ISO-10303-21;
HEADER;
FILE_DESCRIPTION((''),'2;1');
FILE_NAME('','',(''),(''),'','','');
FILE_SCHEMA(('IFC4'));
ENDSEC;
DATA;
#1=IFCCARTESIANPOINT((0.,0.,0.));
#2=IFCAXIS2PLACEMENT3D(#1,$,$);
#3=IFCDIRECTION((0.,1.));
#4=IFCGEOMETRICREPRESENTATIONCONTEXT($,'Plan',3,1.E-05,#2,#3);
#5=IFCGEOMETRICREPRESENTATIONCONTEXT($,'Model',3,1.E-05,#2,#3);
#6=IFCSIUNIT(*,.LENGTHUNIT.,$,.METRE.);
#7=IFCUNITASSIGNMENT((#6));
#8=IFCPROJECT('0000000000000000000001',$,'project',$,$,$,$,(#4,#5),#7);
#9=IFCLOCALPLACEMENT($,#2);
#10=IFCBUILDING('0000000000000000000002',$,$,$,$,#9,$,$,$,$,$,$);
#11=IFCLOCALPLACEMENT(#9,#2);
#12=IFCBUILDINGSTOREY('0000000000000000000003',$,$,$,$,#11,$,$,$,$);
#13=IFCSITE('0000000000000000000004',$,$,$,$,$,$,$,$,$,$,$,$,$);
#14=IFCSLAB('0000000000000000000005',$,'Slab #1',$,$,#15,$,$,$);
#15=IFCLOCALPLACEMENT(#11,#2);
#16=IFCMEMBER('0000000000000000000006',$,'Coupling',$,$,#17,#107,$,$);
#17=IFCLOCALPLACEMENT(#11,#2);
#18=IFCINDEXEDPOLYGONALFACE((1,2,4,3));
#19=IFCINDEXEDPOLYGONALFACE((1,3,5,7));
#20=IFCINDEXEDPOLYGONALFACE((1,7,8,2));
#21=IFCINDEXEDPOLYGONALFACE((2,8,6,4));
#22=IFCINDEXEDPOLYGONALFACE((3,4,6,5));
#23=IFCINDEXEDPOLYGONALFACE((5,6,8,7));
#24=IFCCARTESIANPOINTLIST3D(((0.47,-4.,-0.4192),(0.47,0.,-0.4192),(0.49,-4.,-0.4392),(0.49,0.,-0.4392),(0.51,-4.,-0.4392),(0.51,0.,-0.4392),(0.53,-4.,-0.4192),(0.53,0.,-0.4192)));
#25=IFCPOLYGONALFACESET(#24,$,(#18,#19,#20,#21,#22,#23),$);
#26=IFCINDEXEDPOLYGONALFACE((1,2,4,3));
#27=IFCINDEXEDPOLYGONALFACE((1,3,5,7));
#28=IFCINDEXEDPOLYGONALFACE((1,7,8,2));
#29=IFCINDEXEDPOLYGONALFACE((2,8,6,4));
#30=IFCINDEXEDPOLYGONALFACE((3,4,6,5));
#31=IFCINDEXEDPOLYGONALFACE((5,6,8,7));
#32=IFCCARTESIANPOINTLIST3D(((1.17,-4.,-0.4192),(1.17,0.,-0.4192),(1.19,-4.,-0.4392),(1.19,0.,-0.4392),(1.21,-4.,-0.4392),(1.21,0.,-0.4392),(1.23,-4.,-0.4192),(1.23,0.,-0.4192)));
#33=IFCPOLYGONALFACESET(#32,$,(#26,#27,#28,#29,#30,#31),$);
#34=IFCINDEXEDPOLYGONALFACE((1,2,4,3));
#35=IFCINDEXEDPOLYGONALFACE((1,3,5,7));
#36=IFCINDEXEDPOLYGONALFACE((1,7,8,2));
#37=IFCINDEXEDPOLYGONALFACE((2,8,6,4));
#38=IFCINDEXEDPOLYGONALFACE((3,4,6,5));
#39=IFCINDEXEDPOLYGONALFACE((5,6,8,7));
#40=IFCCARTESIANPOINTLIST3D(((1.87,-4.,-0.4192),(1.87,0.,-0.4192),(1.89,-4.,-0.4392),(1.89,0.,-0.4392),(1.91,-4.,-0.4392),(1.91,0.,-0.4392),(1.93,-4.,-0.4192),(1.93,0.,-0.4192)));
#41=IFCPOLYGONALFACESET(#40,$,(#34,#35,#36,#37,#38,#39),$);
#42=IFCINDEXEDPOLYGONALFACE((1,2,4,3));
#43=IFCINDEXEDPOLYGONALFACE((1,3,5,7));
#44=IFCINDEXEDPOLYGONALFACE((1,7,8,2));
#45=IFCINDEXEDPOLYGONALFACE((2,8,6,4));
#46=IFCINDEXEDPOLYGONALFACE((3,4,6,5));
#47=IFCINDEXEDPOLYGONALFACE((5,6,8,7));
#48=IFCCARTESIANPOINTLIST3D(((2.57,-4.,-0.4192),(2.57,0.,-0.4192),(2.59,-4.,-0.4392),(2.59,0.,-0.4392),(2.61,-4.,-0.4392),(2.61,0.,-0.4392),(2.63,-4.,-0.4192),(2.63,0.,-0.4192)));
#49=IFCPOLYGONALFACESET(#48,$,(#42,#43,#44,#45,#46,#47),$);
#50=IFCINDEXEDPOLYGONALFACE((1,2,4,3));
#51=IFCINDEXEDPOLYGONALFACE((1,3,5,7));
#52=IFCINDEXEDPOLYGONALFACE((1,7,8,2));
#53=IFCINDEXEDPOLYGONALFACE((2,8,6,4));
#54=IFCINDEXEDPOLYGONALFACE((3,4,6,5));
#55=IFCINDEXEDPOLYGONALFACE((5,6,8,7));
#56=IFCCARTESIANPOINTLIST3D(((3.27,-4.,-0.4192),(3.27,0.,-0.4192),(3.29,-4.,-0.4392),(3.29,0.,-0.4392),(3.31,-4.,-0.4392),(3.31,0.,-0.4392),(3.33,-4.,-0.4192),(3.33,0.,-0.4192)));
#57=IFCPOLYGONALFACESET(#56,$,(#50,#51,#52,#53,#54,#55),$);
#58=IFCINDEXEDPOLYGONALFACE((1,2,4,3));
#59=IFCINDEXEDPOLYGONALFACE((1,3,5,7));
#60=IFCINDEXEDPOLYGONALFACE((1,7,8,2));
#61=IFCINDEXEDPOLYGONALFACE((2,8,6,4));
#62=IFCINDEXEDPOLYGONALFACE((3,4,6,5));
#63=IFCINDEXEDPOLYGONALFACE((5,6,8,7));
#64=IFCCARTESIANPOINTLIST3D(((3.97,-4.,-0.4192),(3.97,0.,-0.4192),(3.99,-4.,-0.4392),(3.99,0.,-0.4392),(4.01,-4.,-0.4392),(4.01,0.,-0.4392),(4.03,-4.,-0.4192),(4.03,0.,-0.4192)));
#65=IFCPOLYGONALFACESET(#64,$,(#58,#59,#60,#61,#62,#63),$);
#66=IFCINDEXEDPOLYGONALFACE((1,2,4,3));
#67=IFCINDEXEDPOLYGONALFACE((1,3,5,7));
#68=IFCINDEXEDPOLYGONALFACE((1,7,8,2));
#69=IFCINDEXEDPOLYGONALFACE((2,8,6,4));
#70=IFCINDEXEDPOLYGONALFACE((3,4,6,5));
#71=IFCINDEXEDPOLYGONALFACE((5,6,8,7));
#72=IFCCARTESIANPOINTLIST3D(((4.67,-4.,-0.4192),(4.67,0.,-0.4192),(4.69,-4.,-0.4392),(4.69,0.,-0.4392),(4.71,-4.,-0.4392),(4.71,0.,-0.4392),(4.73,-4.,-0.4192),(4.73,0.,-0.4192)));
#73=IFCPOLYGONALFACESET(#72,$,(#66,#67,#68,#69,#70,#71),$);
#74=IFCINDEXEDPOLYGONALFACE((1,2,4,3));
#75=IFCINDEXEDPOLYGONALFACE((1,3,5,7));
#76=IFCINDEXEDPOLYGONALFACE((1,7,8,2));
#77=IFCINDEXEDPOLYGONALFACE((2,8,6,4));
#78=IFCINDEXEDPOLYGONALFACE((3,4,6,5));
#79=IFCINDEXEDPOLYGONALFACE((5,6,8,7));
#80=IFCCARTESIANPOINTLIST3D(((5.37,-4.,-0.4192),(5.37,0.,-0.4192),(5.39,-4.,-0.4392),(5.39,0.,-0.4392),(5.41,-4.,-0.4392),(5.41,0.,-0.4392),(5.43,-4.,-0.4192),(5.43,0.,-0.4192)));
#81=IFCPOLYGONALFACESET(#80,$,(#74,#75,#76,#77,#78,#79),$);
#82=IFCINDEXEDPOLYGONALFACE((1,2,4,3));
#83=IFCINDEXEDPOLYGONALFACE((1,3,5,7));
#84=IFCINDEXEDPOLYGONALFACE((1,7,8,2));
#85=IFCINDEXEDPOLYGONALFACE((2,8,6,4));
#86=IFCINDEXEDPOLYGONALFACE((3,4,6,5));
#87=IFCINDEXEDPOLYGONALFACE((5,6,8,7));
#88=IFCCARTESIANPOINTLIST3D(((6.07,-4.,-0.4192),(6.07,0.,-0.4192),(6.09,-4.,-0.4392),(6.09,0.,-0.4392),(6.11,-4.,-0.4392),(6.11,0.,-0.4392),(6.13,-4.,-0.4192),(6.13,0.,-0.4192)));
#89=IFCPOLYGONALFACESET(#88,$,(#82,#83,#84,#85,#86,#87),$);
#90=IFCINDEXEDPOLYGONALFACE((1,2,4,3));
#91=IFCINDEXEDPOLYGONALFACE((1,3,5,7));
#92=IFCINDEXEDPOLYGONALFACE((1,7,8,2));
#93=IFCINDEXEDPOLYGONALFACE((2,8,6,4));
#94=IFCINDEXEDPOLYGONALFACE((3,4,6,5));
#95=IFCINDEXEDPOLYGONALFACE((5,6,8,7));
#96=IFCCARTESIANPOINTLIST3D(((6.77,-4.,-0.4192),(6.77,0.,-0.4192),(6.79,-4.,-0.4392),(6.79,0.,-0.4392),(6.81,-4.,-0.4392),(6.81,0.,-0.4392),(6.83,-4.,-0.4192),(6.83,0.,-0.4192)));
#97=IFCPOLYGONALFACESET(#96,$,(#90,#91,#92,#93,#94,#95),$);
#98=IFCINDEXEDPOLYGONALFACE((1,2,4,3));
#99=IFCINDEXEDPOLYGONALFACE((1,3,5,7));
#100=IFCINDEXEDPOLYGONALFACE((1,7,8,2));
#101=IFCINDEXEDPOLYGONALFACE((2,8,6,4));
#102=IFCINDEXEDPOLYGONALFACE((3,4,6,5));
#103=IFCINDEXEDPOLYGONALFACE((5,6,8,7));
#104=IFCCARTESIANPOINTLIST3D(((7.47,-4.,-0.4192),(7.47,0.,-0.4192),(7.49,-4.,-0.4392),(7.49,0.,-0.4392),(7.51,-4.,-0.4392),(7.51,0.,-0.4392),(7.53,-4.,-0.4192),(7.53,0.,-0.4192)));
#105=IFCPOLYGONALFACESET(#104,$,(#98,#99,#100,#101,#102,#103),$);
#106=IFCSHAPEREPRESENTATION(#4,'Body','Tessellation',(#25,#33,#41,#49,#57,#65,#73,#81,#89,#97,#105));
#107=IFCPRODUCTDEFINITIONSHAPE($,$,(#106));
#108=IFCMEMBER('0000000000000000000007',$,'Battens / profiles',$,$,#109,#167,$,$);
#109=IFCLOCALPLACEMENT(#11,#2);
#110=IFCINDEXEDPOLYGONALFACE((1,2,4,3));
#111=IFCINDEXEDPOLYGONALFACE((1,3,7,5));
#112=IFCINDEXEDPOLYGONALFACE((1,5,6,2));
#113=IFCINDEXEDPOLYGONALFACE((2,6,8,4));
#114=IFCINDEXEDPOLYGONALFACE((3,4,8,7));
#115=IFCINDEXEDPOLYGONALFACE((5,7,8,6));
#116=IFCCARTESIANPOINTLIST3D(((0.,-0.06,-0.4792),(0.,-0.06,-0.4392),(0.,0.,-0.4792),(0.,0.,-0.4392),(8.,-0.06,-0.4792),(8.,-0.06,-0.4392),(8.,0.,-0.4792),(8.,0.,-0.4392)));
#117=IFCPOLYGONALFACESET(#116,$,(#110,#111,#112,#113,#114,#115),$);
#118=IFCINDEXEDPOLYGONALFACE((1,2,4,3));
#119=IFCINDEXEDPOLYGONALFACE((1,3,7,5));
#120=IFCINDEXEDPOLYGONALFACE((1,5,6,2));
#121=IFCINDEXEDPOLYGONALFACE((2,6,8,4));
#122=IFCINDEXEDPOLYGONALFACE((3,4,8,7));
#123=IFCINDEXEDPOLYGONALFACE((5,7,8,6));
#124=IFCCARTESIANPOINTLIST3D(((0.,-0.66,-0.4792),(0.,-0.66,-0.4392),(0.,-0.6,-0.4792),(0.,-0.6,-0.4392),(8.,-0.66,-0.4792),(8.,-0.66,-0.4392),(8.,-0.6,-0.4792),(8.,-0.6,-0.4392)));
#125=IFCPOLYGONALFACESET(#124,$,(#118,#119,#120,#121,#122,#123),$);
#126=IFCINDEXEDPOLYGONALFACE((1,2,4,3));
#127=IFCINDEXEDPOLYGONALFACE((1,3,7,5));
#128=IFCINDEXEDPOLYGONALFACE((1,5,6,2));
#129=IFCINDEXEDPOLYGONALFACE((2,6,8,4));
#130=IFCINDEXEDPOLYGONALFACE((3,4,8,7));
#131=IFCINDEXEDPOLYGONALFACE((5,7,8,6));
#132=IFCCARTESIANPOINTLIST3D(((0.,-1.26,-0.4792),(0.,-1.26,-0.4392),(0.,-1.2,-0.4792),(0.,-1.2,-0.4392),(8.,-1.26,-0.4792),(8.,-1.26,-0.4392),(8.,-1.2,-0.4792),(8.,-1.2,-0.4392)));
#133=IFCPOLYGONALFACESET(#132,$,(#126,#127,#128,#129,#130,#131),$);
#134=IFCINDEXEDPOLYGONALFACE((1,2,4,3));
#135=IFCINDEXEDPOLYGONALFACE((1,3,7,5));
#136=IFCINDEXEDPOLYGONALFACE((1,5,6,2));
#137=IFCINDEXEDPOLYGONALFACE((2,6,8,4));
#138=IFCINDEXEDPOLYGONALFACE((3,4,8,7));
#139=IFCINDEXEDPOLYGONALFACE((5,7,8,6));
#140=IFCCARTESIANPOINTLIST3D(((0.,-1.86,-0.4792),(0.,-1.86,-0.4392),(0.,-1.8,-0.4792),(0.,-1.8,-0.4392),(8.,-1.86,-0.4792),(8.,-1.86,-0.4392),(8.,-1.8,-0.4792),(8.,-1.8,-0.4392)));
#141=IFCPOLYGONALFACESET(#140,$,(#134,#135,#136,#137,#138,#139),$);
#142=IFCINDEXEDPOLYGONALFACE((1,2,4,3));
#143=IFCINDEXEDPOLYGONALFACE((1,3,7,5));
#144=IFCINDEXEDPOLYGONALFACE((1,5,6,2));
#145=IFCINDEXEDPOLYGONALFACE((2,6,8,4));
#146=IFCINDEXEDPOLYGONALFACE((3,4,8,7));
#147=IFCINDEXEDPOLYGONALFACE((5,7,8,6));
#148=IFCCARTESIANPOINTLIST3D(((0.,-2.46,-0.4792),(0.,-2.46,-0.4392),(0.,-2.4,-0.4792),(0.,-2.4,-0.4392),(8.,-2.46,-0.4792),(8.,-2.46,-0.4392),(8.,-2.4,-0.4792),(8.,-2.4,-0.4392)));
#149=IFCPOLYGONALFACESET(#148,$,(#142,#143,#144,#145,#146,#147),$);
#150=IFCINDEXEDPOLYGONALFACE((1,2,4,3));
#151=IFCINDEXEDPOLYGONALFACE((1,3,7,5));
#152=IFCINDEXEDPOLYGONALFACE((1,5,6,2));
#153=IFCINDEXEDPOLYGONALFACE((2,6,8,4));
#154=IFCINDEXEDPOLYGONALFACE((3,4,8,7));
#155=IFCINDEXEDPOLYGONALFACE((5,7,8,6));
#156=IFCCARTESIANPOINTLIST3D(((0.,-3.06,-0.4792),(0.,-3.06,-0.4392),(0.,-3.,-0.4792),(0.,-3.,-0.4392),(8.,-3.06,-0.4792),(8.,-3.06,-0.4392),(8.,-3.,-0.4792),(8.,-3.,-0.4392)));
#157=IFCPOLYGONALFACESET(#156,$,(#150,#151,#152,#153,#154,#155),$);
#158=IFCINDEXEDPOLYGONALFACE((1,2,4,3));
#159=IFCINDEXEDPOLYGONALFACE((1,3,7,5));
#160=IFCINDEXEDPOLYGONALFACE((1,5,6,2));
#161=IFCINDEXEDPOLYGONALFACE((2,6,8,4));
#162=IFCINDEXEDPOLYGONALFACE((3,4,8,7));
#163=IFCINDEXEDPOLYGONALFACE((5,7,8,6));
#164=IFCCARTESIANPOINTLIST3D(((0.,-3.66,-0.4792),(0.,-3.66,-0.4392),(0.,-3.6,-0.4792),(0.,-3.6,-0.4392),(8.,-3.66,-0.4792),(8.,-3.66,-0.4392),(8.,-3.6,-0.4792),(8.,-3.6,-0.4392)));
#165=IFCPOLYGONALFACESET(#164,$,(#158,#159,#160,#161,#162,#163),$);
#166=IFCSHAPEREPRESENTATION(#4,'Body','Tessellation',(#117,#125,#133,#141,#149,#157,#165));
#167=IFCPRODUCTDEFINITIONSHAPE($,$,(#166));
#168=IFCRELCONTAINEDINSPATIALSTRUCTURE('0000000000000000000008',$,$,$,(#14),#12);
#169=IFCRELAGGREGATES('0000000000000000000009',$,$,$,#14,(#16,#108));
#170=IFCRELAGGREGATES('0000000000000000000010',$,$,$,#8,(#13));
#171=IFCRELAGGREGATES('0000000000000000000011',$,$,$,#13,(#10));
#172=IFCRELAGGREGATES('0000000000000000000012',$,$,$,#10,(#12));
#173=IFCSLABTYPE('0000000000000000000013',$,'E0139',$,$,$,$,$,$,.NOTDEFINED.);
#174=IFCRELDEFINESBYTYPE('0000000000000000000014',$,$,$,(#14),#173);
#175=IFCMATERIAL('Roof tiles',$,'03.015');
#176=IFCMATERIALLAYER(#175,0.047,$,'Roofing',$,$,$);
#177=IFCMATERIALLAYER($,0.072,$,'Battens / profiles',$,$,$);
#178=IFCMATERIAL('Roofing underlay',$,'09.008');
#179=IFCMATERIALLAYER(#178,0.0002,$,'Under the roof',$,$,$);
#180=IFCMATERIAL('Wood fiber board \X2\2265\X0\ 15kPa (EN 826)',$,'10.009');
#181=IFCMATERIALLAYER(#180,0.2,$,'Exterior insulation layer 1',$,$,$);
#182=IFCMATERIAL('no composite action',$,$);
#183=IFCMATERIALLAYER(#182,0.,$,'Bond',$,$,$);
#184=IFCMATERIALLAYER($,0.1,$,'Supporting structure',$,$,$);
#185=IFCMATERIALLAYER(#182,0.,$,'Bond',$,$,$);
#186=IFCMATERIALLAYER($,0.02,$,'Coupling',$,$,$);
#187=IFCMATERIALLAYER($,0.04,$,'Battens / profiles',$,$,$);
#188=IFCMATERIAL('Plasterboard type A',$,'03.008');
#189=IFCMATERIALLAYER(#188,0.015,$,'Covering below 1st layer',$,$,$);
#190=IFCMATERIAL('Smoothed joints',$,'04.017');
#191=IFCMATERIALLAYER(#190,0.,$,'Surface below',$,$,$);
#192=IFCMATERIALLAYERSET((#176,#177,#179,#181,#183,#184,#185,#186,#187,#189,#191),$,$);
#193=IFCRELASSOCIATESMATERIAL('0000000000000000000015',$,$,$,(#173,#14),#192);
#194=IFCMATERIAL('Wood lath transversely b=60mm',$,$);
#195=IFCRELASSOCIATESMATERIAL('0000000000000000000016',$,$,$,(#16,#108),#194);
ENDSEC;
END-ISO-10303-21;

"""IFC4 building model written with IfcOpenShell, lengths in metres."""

from ifc_helpers import new_model, si_unit, direction, frame, frame_2d, origin, place, context, project, spatial, polyline, rectangle, outline, extrude, material, layer, layer_set, type_object, element, aggregate, save


model = new_model("IFC4")

# Units and contexts
plan_context = context("Plan", 3, precision=1e-05, world=origin(), true_north=direction((0.0, 1.0)))
model_context = context("Model", 3, precision=1e-05, world=origin(), true_north=direction((0.0, 1.0)))
ifc_project = project(units=[si_unit("LENGTHUNIT", "METRE")], contexts=[plan_context, model_context])

# Site, building, storey
site = spatial("IfcSite", under=ifc_project)
building_placement = place(None, origin())
building = spatial("IfcBuilding", under=site, at=building_placement)
storey_placement = place(building_placement, origin())
storey = spatial("IfcBuildingStorey", under=building, at=storey_placement)

# Slab, members
ifc_material_1 = material(Name="Roof tiles", Category="03.015")
ifc_layer_1 = layer(ifc_material_1, 0.047, Name="Roofing")
ifc_layer_2 = layer(None, 0.072, Name="Battens / profiles")
ifc_material_2 = material(Name="Roofing underlay", Category="09.008")
ifc_layer_3 = layer(ifc_material_2, 0.0002, Name="Under the roof")
ifc_material_3 = material(Name="Wood fiber board ≥ 15kPa (EN 826)", Category="10.009")
ifc_layer_4 = layer(ifc_material_3, 0.2, Name="Exterior insulation layer 1")
ifc_material_4 = material(Name="no composite action")
ifc_layer_5 = layer(ifc_material_4, 0.0, Name="Bond")
ifc_layer_6 = layer(None, 0.1, Name="Supporting structure")
ifc_layer_7 = layer(ifc_material_4, 0.0, Name="Bond")
ifc_layer_8 = layer(None, 0.02, Name="Coupling")
ifc_layer_9 = layer(None, 0.04, Name="Battens / profiles")
ifc_material_5 = material(Name="Plasterboard type A", Category="03.008")
ifc_layer_10 = layer(ifc_material_5, 0.015, Name="Covering below 1st layer")
ifc_material_6 = material(Name="Smoothed joints", Category="04.017")
ifc_layer_11 = layer(ifc_material_6, 0.0, Name="Surface below")
ifc_layer_set = layer_set([ifc_layer_1, ifc_layer_2, ifc_layer_3, ifc_layer_4, ifc_layer_5, ifc_layer_6, ifc_layer_7, ifc_layer_8, ifc_layer_9, ifc_layer_10, ifc_layer_11])
slab_type = type_object("IfcSlabType", Name="E0139", PredefinedType="NOTDEFINED", material=ifc_layer_set)
slab_placement = place(None, frame((0.0, 0.0, 0.0), z_axis=(0.0, 0.0, -1.0), x_axis=(1.0, 0.0, 0.0)))
slab = element("IfcSlab", 1, at=slab_placement, inside=storey, type_object=slab_type, material=ifc_layer_set, Name="Slab #1")
ifc_material_7 = material(Name="Wood lath transversely b=60mm")
member_1_placement = place(slab_placement, origin())
member_1 = element("IfcMember", 2, at=member_1_placement, material=ifc_material_7, Name="Coupling", context=plan_context, shape_type="SweptSolid", body=[
    extrude(outline(polyline([(0.0, 0.0), (0.06, 0.0), (0.04, 0.02), (0.02, 0.02), (0.0, 0.0)])), frame((0.47, 4.0, 0.4192), z_axis=(0.0, -1.0, 0.0), x_axis=(1.0, 0.0, 0.0)), (0.0, 0.0, 1.0), 4.0),
    extrude(outline(polyline([(0.0, 0.0), (0.06, 0.0), (0.04, 0.02), (0.02, 0.02), (0.0, 0.0)])), frame((1.17, 4.0, 0.4192), z_axis=(0.0, -1.0, 0.0), x_axis=(1.0, 0.0, 0.0)), (0.0, 0.0, 1.0), 4.0),
    extrude(outline(polyline([(0.0, 0.0), (0.06, 0.0), (0.04, 0.02), (0.02, 0.02), (0.0, 0.0)])), frame((1.87, 4.0, 0.4192), z_axis=(0.0, -1.0, 0.0), x_axis=(1.0, 0.0, 0.0)), (0.0, 0.0, 1.0), 4.0),
    extrude(outline(polyline([(0.0, 0.0), (0.06, 0.0), (0.04, 0.02), (0.02, 0.02), (0.0, 0.0)])), frame((2.57, 4.0, 0.4192), z_axis=(0.0, -1.0, 0.0), x_axis=(1.0, 0.0, 0.0)), (0.0, 0.0, 1.0), 4.0),
    extrude(outline(polyline([(0.0, 0.0), (0.06, 0.0), (0.04, 0.02), (0.02, 0.02), (0.0, 0.0)])), frame((3.27, 4.0, 0.4192), z_axis=(0.0, -1.0, 0.0), x_axis=(1.0, 0.0, 0.0)), (0.0, 0.0, 1.0), 4.0),
    extrude(outline(polyline([(0.0, 0.0), (0.06, 0.0), (0.04, 0.02), (0.02, 0.02), (0.0, 0.0)])), frame((3.97, 4.0, 0.4192), z_axis=(0.0, -1.0, 0.0), x_axis=(1.0, 0.0, 0.0)), (0.0, 0.0, 1.0), 4.0),
    extrude(outline(polyline([(0.0, 0.0), (0.06, 0.0), (0.04, 0.02), (0.02, 0.02), (0.0, 0.0)])), frame((4.67, 4.0, 0.4192), z_axis=(0.0, -1.0, 0.0), x_axis=(1.0, 0.0, 0.0)), (0.0, 0.0, 1.0), 4.0),
    extrude(outline(polyline([(0.0, 0.0), (0.06, 0.0), (0.04, 0.02), (0.02, 0.02), (0.0, 0.0)])), frame((5.37, 4.0, 0.4192), z_axis=(0.0, -1.0, 0.0), x_axis=(1.0, 0.0, 0.0)), (0.0, 0.0, 1.0), 4.0),
    extrude(outline(polyline([(0.0, 0.0), (0.06, 0.0), (0.04, 0.02), (0.02, 0.02), (0.0, 0.0)])), frame((6.07, 4.0, 0.4192), z_axis=(0.0, -1.0, 0.0), x_axis=(1.0, 0.0, 0.0)), (0.0, 0.0, 1.0), 4.0),
    extrude(outline(polyline([(0.0, 0.0), (0.06, 0.0), (0.04, 0.02), (0.02, 0.02), (0.0, 0.0)])), frame((6.77, 4.0, 0.4192), z_axis=(0.0, -1.0, 0.0), x_axis=(1.0, 0.0, 0.0)), (0.0, 0.0, 1.0), 4.0),
    extrude(outline(polyline([(0.0, 0.0), (0.06, 0.0), (0.04, 0.02), (0.02, 0.02), (0.0, 0.0)])), frame((7.47, 4.0, 0.4192), z_axis=(0.0, -1.0, 0.0), x_axis=(1.0, 0.0, 0.0)), (0.0, 0.0, 1.0), 4.0),
])
member_2_placement = place(slab_placement, origin())
member_2 = element("IfcMember", 3, at=member_2_placement, material=ifc_material_7, Name="Battens / profiles", context=plan_context, shape_type="SweptSolid", body=[
    extrude(rectangle(XDim=0.06, YDim=0.04, at=frame_2d((0.03, 0.02), x_axis=(1.0, 0.0))), frame((0.0, 0.0, 0.4392), z_axis=(1.0, 0.0, 0.0), x_axis=(0.0, 1.0, 0.0)), (0.0, 0.0, 1.0), 8.0),
    extrude(rectangle(XDim=0.06, YDim=0.04, at=frame_2d((0.03, 0.02), x_axis=(1.0, 0.0))), frame((0.0, 0.6, 0.4392), z_axis=(1.0, 0.0, 0.0), x_axis=(0.0, 1.0, 0.0)), (0.0, 0.0, 1.0), 8.0),
    extrude(rectangle(XDim=0.06, YDim=0.04, at=frame_2d((0.03, 0.02), x_axis=(1.0, 0.0))), frame((0.0, 1.2, 0.4392), z_axis=(1.0, 0.0, 0.0), x_axis=(0.0, 1.0, 0.0)), (0.0, 0.0, 1.0), 8.0),
    extrude(rectangle(XDim=0.06, YDim=0.04, at=frame_2d((0.03, 0.02), x_axis=(1.0, 0.0))), frame((0.0, 1.8, 0.4392), z_axis=(1.0, 0.0, 0.0), x_axis=(0.0, 1.0, 0.0)), (0.0, 0.0, 1.0), 8.0),
    extrude(rectangle(XDim=0.06, YDim=0.04, at=frame_2d((0.03, 0.02), x_axis=(1.0, 0.0))), frame((0.0, 2.4, 0.4392), z_axis=(1.0, 0.0, 0.0), x_axis=(0.0, 1.0, 0.0)), (0.0, 0.0, 1.0), 8.0),
    extrude(rectangle(XDim=0.06, YDim=0.04, at=frame_2d((0.03, 0.02), x_axis=(1.0, 0.0))), frame((0.0, 3.0, 0.4392), z_axis=(1.0, 0.0, 0.0), x_axis=(0.0, 1.0, 0.0)), (0.0, 0.0, 1.0), 8.0),
    extrude(rectangle(XDim=0.06, YDim=0.04, at=frame_2d((0.03, 0.02), x_axis=(1.0, 0.0))), frame((0.0, 3.6, 0.4392), z_axis=(1.0, 0.0, 0.0), x_axis=(0.0, 1.0, 0.0)), (0.0, 0.0, 1.0), 8.0),
])
aggregate(slab, [member_1, member_2])

save(model, "model.ifc")
